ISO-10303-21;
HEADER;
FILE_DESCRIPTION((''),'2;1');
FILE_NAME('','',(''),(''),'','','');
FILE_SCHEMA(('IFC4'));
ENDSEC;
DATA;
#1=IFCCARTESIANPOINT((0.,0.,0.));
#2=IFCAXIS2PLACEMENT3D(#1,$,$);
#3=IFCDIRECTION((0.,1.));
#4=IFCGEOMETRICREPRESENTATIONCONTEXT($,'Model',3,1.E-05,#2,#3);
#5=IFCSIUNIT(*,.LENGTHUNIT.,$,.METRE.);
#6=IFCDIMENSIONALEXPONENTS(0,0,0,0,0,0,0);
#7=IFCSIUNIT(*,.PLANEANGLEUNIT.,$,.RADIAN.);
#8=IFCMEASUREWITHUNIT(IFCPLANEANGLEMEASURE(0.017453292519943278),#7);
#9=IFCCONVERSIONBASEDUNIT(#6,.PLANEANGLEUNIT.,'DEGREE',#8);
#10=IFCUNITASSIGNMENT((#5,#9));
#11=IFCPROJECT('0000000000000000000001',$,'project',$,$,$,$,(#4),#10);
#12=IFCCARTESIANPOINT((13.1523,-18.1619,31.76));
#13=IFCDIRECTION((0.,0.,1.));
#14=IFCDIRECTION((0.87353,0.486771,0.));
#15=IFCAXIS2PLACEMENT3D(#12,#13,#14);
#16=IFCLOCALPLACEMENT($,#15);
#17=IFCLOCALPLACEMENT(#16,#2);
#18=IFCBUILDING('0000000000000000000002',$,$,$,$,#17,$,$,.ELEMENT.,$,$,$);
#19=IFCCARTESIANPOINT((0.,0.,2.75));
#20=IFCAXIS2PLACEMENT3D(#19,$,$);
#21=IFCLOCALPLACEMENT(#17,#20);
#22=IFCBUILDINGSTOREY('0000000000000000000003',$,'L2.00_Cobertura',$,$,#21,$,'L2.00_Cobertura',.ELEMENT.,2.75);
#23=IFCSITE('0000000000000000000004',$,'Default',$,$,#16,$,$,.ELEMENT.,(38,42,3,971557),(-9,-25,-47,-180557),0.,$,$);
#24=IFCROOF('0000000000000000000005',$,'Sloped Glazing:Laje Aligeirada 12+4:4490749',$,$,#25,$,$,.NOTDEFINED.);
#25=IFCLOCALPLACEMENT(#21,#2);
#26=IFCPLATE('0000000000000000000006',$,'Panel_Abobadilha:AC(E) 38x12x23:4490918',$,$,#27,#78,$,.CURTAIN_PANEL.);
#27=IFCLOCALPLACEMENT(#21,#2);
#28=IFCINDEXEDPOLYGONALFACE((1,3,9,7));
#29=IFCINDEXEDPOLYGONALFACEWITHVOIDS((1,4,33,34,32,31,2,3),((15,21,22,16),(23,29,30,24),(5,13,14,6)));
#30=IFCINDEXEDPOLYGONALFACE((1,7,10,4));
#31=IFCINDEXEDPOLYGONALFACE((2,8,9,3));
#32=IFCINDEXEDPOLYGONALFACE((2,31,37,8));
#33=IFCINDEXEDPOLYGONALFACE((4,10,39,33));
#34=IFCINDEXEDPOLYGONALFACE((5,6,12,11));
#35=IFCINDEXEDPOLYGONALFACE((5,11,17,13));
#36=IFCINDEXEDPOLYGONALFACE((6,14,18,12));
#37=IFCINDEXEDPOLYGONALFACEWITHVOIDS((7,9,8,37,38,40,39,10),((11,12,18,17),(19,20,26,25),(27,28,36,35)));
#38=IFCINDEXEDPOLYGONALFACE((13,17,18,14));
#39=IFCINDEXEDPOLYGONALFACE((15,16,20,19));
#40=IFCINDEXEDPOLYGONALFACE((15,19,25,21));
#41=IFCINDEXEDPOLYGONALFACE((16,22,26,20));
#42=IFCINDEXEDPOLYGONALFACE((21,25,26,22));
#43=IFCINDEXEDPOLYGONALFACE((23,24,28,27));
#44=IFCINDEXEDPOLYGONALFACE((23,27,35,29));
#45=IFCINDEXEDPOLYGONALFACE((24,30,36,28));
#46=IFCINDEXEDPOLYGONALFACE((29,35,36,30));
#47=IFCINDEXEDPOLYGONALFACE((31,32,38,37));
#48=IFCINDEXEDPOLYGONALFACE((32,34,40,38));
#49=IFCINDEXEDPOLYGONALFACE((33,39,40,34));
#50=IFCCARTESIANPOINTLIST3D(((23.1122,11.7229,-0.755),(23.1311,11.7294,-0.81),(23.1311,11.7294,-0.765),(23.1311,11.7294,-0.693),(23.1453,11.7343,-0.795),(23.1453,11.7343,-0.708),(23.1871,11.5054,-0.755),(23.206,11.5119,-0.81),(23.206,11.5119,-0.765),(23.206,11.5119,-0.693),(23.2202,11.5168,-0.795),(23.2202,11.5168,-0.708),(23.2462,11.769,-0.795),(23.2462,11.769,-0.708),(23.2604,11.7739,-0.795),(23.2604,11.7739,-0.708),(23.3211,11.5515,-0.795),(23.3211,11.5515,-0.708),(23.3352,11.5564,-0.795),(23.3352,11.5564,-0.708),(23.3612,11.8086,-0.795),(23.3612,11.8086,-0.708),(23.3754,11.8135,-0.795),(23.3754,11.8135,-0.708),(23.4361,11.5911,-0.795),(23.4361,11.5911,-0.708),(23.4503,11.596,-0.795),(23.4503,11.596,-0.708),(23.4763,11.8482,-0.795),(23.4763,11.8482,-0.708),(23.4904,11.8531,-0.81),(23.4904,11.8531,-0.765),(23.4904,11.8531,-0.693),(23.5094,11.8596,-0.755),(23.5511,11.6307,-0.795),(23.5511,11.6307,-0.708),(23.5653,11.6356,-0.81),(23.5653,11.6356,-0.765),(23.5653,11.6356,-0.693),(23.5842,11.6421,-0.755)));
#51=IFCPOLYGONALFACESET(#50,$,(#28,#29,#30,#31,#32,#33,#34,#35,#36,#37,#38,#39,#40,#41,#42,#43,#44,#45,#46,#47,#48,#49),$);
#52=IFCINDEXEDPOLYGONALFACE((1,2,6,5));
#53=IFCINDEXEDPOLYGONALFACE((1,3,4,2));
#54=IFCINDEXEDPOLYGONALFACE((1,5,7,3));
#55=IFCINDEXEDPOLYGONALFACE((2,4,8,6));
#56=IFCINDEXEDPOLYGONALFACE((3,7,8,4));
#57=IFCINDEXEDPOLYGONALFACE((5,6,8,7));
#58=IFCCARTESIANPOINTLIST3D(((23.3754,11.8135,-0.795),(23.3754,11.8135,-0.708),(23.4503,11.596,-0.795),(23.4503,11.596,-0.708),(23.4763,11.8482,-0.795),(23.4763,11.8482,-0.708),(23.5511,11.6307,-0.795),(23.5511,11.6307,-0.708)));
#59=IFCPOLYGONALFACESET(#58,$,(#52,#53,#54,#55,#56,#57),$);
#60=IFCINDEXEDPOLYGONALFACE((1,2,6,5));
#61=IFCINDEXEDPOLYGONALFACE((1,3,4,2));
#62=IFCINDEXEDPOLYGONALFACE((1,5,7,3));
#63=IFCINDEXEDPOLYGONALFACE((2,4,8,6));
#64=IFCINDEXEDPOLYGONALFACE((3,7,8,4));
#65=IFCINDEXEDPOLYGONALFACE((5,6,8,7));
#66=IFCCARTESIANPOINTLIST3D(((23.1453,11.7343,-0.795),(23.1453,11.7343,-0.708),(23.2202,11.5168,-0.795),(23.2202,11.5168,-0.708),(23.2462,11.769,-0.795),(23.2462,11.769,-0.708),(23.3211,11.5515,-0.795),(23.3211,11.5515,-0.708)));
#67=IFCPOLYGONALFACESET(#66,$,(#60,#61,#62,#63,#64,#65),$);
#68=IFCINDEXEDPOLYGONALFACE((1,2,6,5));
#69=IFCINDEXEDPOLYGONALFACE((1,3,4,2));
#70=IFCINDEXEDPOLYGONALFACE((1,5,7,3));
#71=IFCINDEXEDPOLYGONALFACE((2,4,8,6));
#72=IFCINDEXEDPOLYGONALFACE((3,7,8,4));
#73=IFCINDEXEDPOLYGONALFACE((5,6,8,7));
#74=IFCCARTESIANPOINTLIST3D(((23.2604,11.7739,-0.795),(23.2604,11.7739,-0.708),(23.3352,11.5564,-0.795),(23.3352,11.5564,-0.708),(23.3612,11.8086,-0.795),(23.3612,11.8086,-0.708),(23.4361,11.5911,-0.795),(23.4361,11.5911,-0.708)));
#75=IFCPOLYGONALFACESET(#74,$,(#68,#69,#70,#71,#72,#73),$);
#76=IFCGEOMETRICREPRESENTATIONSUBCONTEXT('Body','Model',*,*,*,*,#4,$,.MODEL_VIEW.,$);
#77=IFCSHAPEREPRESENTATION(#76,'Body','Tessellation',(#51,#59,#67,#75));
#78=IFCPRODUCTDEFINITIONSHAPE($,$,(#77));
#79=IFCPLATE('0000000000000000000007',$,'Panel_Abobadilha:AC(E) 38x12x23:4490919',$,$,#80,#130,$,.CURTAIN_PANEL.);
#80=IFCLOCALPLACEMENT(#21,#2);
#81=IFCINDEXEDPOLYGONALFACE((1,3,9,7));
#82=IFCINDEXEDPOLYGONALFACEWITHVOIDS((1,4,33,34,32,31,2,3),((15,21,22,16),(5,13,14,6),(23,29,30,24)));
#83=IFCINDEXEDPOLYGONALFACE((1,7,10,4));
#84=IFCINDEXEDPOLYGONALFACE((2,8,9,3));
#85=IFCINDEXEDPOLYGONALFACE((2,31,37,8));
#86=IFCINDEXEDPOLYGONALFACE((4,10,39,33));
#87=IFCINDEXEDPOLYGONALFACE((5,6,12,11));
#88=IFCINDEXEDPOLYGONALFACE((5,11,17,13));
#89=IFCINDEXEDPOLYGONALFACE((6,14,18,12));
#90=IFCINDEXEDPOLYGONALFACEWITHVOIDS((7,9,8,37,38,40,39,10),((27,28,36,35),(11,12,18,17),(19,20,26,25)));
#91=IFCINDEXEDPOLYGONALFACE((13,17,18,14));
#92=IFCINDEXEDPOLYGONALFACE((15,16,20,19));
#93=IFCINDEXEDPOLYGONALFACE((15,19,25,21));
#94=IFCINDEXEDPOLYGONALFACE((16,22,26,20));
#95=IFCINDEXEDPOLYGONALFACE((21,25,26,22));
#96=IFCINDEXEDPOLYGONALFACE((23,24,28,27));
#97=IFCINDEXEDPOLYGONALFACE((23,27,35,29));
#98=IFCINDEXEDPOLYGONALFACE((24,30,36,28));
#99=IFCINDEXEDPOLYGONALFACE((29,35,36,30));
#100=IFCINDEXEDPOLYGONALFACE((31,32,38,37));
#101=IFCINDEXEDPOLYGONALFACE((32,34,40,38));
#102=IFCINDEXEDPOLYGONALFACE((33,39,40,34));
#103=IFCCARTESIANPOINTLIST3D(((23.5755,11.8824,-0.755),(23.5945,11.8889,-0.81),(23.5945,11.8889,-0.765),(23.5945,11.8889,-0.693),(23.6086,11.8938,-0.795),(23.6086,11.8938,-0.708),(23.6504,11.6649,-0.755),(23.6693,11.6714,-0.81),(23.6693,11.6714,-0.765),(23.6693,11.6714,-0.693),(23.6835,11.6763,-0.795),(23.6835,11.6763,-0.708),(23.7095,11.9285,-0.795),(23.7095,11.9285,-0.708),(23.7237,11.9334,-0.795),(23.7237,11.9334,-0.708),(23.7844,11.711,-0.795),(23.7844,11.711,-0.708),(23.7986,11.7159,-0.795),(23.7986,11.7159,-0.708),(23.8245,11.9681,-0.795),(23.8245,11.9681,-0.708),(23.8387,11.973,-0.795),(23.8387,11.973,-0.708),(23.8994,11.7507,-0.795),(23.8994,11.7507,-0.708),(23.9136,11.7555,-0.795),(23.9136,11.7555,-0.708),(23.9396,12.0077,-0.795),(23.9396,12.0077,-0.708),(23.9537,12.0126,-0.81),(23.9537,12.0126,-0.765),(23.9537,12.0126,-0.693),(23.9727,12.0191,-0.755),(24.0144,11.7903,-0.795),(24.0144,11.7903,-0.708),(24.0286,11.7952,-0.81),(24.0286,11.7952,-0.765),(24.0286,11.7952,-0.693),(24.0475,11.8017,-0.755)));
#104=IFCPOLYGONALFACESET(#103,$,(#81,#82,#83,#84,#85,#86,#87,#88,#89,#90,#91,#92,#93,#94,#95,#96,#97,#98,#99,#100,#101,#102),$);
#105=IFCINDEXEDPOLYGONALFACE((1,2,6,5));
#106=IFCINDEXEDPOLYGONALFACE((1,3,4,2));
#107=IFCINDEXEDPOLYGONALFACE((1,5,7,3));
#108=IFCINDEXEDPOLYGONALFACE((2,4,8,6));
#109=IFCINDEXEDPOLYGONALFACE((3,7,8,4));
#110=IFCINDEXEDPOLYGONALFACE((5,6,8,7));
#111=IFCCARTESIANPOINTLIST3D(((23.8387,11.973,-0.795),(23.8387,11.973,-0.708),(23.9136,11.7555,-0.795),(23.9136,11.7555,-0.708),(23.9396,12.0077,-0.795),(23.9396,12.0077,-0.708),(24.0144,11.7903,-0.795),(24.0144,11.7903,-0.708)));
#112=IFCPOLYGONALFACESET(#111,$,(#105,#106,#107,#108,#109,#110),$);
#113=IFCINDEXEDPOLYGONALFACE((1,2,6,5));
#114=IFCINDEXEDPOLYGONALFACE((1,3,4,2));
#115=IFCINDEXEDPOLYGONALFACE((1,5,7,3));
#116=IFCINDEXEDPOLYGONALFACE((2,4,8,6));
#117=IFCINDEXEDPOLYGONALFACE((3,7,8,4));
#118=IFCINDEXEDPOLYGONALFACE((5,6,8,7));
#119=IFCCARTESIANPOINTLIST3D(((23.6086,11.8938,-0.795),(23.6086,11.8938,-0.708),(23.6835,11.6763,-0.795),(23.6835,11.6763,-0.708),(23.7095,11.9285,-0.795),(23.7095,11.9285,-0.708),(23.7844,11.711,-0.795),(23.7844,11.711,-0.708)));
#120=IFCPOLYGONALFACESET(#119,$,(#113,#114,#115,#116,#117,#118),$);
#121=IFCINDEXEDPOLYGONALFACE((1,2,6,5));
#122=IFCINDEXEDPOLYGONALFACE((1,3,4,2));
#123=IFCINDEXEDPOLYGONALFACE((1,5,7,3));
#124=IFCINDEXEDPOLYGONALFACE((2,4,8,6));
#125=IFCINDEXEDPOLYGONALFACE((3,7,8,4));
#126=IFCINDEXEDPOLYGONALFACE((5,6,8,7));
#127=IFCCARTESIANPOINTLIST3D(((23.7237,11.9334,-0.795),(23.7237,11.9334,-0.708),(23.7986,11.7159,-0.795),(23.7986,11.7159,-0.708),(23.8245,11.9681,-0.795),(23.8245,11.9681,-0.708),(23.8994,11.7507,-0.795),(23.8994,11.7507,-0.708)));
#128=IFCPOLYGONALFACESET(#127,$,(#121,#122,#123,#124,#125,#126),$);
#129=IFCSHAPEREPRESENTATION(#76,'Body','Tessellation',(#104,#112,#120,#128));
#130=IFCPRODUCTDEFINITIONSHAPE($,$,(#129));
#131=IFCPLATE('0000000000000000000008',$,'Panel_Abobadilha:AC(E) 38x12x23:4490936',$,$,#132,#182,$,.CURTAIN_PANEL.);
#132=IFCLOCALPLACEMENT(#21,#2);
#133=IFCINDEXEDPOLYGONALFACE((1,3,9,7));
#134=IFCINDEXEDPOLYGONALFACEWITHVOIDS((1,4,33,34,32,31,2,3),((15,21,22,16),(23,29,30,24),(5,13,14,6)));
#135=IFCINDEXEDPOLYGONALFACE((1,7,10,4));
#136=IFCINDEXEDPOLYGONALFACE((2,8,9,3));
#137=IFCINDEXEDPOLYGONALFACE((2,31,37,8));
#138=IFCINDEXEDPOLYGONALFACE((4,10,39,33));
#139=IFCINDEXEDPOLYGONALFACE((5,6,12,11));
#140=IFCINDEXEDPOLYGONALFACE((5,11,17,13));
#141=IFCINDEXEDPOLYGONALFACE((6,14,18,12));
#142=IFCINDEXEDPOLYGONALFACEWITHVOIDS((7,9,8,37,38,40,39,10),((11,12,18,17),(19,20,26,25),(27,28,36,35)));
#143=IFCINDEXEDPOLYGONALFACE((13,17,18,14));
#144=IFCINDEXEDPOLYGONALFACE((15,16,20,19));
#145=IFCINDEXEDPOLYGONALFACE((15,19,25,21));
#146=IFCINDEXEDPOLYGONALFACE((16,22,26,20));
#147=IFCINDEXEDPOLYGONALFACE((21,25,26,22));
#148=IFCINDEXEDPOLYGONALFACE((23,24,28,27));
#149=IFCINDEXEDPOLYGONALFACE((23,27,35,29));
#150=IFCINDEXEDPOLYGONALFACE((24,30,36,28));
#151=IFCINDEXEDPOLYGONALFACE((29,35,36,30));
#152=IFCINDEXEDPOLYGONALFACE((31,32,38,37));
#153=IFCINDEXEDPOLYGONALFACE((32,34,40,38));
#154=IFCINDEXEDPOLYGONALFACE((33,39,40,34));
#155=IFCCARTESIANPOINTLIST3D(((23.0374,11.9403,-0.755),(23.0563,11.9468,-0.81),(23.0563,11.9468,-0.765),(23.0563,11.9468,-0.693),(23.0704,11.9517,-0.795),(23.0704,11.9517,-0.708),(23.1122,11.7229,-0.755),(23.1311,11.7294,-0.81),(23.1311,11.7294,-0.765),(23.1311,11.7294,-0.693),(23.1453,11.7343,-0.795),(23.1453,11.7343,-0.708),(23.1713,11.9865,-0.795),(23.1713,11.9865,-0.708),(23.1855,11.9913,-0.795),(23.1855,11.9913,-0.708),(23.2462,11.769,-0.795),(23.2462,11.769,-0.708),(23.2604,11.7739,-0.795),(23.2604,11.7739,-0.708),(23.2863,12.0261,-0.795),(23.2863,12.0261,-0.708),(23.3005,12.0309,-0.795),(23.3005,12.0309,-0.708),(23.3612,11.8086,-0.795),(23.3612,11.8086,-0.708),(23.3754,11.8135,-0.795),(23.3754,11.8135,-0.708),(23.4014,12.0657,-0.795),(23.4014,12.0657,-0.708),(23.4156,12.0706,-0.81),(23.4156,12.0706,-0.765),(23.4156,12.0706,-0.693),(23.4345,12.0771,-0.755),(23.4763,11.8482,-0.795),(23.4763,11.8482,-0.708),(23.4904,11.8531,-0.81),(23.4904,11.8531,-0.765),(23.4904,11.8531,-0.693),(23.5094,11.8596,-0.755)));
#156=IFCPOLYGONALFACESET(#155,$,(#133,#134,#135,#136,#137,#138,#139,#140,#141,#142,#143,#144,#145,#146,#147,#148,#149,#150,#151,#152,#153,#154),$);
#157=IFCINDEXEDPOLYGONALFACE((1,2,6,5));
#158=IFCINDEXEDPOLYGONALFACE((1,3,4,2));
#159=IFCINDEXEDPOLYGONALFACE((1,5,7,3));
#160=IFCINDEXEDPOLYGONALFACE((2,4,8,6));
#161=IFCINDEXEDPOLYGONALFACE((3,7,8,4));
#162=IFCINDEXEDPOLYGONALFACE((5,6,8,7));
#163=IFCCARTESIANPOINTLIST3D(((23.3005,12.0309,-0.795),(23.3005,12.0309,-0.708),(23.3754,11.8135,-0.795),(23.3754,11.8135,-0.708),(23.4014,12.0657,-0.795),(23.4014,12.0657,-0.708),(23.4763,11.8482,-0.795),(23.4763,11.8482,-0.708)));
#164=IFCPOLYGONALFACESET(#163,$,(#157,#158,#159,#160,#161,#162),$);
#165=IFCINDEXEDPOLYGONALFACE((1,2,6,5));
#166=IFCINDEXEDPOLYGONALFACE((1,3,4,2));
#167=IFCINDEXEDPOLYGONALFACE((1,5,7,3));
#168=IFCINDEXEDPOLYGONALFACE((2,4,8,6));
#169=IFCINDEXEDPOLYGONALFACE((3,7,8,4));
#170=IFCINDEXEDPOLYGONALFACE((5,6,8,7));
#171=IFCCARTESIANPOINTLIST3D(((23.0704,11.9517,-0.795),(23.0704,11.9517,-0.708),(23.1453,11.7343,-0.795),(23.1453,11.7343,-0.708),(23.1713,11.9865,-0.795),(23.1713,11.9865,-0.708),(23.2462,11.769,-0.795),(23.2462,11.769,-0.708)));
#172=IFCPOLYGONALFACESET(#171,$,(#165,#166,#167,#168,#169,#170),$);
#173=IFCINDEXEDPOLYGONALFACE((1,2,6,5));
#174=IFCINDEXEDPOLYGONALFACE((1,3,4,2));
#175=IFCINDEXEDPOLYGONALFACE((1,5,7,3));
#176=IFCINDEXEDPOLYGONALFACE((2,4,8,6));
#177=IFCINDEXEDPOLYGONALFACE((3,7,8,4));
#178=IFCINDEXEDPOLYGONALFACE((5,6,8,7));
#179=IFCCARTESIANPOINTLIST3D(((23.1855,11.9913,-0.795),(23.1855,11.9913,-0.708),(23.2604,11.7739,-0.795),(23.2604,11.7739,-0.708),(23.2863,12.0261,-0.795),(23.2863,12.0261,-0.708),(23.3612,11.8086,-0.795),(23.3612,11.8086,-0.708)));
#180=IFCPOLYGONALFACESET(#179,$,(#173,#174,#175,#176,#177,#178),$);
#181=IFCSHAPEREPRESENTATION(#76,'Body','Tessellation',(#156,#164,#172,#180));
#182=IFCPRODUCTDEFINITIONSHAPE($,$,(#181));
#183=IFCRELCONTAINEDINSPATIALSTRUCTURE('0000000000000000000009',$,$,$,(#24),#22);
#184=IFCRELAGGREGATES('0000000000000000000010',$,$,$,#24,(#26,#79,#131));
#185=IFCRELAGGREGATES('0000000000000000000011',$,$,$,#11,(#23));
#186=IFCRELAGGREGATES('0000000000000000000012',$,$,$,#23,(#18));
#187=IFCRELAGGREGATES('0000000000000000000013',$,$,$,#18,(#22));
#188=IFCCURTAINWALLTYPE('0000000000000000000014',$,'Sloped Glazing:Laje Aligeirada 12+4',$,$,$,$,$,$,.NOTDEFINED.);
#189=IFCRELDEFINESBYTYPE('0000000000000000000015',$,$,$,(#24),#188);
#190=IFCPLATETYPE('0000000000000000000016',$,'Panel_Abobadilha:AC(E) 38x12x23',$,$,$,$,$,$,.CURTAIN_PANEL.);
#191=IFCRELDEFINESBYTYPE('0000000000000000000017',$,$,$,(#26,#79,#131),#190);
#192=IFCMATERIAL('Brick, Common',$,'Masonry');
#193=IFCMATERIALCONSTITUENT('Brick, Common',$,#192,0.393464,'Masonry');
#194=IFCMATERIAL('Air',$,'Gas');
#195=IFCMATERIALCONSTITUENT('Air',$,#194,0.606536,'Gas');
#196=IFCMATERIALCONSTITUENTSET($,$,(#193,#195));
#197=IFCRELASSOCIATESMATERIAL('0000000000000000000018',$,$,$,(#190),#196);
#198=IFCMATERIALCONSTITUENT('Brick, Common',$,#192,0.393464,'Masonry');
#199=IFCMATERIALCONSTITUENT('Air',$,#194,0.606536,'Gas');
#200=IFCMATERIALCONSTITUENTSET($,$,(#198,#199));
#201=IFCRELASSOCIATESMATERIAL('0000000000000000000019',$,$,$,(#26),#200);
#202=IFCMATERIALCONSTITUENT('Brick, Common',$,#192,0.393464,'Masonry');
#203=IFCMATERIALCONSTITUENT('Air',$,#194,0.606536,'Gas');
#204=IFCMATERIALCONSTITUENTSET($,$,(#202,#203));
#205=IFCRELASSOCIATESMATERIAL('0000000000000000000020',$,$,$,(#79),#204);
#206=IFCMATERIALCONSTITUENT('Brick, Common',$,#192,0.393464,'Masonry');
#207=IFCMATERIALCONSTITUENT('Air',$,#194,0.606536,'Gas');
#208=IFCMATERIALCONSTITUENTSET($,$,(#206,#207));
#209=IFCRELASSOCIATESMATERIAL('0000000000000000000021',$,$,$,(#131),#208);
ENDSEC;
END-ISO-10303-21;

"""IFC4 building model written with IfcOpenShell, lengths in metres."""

from ifc_helpers import new_model, entity, si_unit, converted_unit, direction, frame, origin, place, context, subcontext, project, spatial, indexed_curve, outline, extrude, source, transform, mapped, material, constituent, constituent_set, type_object, type_shapes, element, aggregate, save


model = new_model("IFC4")

# Units and contexts
model_context = context("Model", 3, precision=1e-05, world=origin(), true_north=direction((0.0, 1.0)))
body_context = subcontext(model_context, "Body", "Model", "MODEL_VIEW")
ifc_project = project(units=[si_unit("LENGTHUNIT", "METRE"), converted_unit("PLANEANGLEUNIT", "DEGREE", entity("IfcPlaneAngleMeasure", 0.017453292519943278), si_unit("PLANEANGLEUNIT", "RADIAN"), dimensions=[0, 0, 0, 0, 0, 0, 0])], contexts=[model_context])

# Site, building, storey
site_placement = place(None, frame((13.1523, -18.1619, 31.76), z_axis=(0.0, 0.0, 1.0), x_axis=(0.87353, 0.486771, 0.0)))
site = spatial("IfcSite", under=ifc_project, at=site_placement, Name="Default", CompositionType="ELEMENT", RefLatitude=(38, 42, 3, 971557), RefLongitude=(-9, -25, -47, -180557), RefElevation=0.0)
building_placement = place(site_placement, origin())
building = spatial("IfcBuilding", under=site, at=building_placement, CompositionType="ELEMENT")
storey_placement = place(building_placement, frame((0.0, 0.0, 2.75)))
storey = spatial("IfcBuildingStorey", under=building, at=storey_placement, Name="L2.00_Cobertura", LongName="L2.00_Cobertura", CompositionType="ELEMENT", Elevation=2.75)

# Roof, plates
curtain_wall_type = type_object("IfcCurtainWallType", Name="Sloped Glazing:Laje Aligeirada 12+4", PredefinedType="NOTDEFINED")
roof_placement = place(storey_placement, frame((0.0, 0.0, -2.75)))
roof = element("IfcRoof", 1, at=roof_placement, inside=storey, type_object=curtain_wall_type, Name="Sloped Glazing:Laje Aligeirada 12+4:4490749", PredefinedType="NOTDEFINED")
ifc_material_1 = material(Name="Brick, Common", Category="Masonry")
ifc_material_2 = material(Name="Air", Category="Gas")
ifc_constituent_1 = constituent(ifc_material_1, Name="Brick, Common", Category="Masonry", fraction=0.393464)
ifc_constituent_2 = constituent(ifc_material_2, Name="Air", Category="Gas", fraction=0.606536)
ifc_constituent_set_1 = constituent_set(constituents=[ifc_constituent_1, ifc_constituent_2])
plate_type_1 = type_object("IfcPlateType", Name="Panel_Abobadilha:AC(E) 38x12x23", PredefinedType="CURTAIN_PANEL", material=ifc_constituent_set_1)
shared_shape_1 = source(origin(), body_context, "Body", "SweptSolid", [
    extrude(outline(indexed_curve([(-0.19, -0.0543), (0.19, -0.0543), (0.19, -0.0093), (0.21, 0.0007), (0.19, 0.0628), (-0.19, 0.0628), (-0.21, 0.0007), (-0.19, -0.0093), (-0.19, -0.0543)], self_intersect=False), holes=[indexed_curve([(-0.0683, 0.0477), (-0.0683, -0.0393), (-0.175, -0.0393), (-0.175, 0.0477), (-0.0683, 0.0477)], self_intersect=False), indexed_curve([(0.0533, 0.0477), (0.0533, -0.0393), (-0.0533, -0.0393), (-0.0533, 0.0477), (0.0533, 0.0477)], self_intersect=False), indexed_curve([(0.175, 0.0477), (0.175, -0.0393), (0.0683, -0.0393), (0.0683, 0.0477), (0.175, 0.0477)], self_intersect=False)]), frame((0.0, 0.0543, 0.0)), (0.0, 0.0, 1.0), 0.23),
    extrude(outline(indexed_curve([(-0.0533, -0.0435), (0.0533, -0.0435), (0.0533, 0.0435), (-0.0533, 0.0435), (-0.0533, -0.0435)], self_intersect=False)), frame((0.1217, 0.0585, 0.0), z_axis=(0.0, 0.0, 1.0), x_axis=(-1.0, 0.0, 0.0)), (0.0, 0.0, 1.0), 0.23),
    extrude(outline(indexed_curve([(-0.0533, -0.0435), (0.0533, -0.0435), (0.0533, 0.0435), (-0.0533, 0.0435), (-0.0533, -0.0435)], self_intersect=False)), frame((-0.1217, 0.0585, 0.0), z_axis=(0.0, 0.0, 1.0), x_axis=(-1.0, 0.0, 0.0)), (0.0, 0.0, 1.0), 0.23),
    extrude(outline(indexed_curve([(-0.0533, -0.0435), (0.0533, -0.0435), (0.0533, 0.0435), (-0.0533, 0.0435), (-0.0533, -0.0435)], self_intersect=False)), frame((0.0, 0.0585, 0.0), z_axis=(0.0, 0.0, 1.0), x_axis=(-1.0, 0.0, 0.0)), (0.0, 0.0, 1.0), 0.23),
])
type_shapes(plate_type_1, [shared_shape_1])
ifc_constituent_3 = constituent(ifc_material_1, Name="Brick, Common", Category="Masonry", fraction=0.393464)
ifc_constituent_4 = constituent(ifc_material_2, Name="Air", Category="Gas", fraction=0.606536)
ifc_constituent_set_2 = constituent_set(constituents=[ifc_constituent_3, ifc_constituent_4])
plate_1_placement = place(roof_placement, frame((23.3108, 11.7912, 1.94), z_axis=(0.325568, -0.945519, 0.0), x_axis=(0.945519, 0.325568, 0.0)))
plate_1 = element("IfcPlate", 2, at=plate_1_placement, type_object=plate_type_1, material=ifc_constituent_set_2, Name="Panel_Abobadilha:AC(E) 38x12x23:4490918", PredefinedType="CURTAIN_PANEL", context=body_context, shape_type="MappedRepresentation", body=[
    mapped(shared_shape_1, transform((0.0, 0.0, 0.0), scale=1.0)),
])
ifc_constituent_5 = constituent(ifc_material_1, Name="Brick, Common", Category="Masonry", fraction=0.393464)
ifc_constituent_6 = constituent(ifc_material_2, Name="Air", Category="Gas", fraction=0.606536)
ifc_constituent_set_3 = constituent_set(constituents=[ifc_constituent_5, ifc_constituent_6])
plate_2_placement = place(roof_placement, frame((23.7741, 11.9508, 1.94), z_axis=(0.325568, -0.945519, 0.0), x_axis=(0.945519, 0.325568, 0.0)))
plate_2 = element("IfcPlate", 3, at=plate_2_placement, type_object=plate_type_1, material=ifc_constituent_set_3, Name="Panel_Abobadilha:AC(E) 38x12x23:4490919", PredefinedType="CURTAIN_PANEL", context=body_context, shape_type="MappedRepresentation", body=[
    mapped(shared_shape_1, transform((0.0, 0.0, 0.0), scale=1.0)),
])
ifc_constituent_7 = constituent(ifc_material_1, Name="Brick, Common", Category="Masonry", fraction=0.393464)
ifc_constituent_8 = constituent(ifc_material_2, Name="Air", Category="Gas", fraction=0.606536)
ifc_constituent_set_4 = constituent_set(constituents=[ifc_constituent_7, ifc_constituent_8])
plate_3_placement = place(roof_placement, frame((23.2359, 12.0087, 1.94), z_axis=(0.325568, -0.945519, 0.0), x_axis=(0.945519, 0.325568, 0.0)))
plate_3 = element("IfcPlate", 4, at=plate_3_placement, type_object=plate_type_1, material=ifc_constituent_set_4, Name="Panel_Abobadilha:AC(E) 38x12x23:4490936", PredefinedType="CURTAIN_PANEL", context=body_context, shape_type="MappedRepresentation", body=[
    mapped(shared_shape_1, transform((0.0, 0.0, 0.0), scale=1.0)),
])
aggregate(roof, [plate_1, plate_2, plate_3])

save(model, "model.ifc")
